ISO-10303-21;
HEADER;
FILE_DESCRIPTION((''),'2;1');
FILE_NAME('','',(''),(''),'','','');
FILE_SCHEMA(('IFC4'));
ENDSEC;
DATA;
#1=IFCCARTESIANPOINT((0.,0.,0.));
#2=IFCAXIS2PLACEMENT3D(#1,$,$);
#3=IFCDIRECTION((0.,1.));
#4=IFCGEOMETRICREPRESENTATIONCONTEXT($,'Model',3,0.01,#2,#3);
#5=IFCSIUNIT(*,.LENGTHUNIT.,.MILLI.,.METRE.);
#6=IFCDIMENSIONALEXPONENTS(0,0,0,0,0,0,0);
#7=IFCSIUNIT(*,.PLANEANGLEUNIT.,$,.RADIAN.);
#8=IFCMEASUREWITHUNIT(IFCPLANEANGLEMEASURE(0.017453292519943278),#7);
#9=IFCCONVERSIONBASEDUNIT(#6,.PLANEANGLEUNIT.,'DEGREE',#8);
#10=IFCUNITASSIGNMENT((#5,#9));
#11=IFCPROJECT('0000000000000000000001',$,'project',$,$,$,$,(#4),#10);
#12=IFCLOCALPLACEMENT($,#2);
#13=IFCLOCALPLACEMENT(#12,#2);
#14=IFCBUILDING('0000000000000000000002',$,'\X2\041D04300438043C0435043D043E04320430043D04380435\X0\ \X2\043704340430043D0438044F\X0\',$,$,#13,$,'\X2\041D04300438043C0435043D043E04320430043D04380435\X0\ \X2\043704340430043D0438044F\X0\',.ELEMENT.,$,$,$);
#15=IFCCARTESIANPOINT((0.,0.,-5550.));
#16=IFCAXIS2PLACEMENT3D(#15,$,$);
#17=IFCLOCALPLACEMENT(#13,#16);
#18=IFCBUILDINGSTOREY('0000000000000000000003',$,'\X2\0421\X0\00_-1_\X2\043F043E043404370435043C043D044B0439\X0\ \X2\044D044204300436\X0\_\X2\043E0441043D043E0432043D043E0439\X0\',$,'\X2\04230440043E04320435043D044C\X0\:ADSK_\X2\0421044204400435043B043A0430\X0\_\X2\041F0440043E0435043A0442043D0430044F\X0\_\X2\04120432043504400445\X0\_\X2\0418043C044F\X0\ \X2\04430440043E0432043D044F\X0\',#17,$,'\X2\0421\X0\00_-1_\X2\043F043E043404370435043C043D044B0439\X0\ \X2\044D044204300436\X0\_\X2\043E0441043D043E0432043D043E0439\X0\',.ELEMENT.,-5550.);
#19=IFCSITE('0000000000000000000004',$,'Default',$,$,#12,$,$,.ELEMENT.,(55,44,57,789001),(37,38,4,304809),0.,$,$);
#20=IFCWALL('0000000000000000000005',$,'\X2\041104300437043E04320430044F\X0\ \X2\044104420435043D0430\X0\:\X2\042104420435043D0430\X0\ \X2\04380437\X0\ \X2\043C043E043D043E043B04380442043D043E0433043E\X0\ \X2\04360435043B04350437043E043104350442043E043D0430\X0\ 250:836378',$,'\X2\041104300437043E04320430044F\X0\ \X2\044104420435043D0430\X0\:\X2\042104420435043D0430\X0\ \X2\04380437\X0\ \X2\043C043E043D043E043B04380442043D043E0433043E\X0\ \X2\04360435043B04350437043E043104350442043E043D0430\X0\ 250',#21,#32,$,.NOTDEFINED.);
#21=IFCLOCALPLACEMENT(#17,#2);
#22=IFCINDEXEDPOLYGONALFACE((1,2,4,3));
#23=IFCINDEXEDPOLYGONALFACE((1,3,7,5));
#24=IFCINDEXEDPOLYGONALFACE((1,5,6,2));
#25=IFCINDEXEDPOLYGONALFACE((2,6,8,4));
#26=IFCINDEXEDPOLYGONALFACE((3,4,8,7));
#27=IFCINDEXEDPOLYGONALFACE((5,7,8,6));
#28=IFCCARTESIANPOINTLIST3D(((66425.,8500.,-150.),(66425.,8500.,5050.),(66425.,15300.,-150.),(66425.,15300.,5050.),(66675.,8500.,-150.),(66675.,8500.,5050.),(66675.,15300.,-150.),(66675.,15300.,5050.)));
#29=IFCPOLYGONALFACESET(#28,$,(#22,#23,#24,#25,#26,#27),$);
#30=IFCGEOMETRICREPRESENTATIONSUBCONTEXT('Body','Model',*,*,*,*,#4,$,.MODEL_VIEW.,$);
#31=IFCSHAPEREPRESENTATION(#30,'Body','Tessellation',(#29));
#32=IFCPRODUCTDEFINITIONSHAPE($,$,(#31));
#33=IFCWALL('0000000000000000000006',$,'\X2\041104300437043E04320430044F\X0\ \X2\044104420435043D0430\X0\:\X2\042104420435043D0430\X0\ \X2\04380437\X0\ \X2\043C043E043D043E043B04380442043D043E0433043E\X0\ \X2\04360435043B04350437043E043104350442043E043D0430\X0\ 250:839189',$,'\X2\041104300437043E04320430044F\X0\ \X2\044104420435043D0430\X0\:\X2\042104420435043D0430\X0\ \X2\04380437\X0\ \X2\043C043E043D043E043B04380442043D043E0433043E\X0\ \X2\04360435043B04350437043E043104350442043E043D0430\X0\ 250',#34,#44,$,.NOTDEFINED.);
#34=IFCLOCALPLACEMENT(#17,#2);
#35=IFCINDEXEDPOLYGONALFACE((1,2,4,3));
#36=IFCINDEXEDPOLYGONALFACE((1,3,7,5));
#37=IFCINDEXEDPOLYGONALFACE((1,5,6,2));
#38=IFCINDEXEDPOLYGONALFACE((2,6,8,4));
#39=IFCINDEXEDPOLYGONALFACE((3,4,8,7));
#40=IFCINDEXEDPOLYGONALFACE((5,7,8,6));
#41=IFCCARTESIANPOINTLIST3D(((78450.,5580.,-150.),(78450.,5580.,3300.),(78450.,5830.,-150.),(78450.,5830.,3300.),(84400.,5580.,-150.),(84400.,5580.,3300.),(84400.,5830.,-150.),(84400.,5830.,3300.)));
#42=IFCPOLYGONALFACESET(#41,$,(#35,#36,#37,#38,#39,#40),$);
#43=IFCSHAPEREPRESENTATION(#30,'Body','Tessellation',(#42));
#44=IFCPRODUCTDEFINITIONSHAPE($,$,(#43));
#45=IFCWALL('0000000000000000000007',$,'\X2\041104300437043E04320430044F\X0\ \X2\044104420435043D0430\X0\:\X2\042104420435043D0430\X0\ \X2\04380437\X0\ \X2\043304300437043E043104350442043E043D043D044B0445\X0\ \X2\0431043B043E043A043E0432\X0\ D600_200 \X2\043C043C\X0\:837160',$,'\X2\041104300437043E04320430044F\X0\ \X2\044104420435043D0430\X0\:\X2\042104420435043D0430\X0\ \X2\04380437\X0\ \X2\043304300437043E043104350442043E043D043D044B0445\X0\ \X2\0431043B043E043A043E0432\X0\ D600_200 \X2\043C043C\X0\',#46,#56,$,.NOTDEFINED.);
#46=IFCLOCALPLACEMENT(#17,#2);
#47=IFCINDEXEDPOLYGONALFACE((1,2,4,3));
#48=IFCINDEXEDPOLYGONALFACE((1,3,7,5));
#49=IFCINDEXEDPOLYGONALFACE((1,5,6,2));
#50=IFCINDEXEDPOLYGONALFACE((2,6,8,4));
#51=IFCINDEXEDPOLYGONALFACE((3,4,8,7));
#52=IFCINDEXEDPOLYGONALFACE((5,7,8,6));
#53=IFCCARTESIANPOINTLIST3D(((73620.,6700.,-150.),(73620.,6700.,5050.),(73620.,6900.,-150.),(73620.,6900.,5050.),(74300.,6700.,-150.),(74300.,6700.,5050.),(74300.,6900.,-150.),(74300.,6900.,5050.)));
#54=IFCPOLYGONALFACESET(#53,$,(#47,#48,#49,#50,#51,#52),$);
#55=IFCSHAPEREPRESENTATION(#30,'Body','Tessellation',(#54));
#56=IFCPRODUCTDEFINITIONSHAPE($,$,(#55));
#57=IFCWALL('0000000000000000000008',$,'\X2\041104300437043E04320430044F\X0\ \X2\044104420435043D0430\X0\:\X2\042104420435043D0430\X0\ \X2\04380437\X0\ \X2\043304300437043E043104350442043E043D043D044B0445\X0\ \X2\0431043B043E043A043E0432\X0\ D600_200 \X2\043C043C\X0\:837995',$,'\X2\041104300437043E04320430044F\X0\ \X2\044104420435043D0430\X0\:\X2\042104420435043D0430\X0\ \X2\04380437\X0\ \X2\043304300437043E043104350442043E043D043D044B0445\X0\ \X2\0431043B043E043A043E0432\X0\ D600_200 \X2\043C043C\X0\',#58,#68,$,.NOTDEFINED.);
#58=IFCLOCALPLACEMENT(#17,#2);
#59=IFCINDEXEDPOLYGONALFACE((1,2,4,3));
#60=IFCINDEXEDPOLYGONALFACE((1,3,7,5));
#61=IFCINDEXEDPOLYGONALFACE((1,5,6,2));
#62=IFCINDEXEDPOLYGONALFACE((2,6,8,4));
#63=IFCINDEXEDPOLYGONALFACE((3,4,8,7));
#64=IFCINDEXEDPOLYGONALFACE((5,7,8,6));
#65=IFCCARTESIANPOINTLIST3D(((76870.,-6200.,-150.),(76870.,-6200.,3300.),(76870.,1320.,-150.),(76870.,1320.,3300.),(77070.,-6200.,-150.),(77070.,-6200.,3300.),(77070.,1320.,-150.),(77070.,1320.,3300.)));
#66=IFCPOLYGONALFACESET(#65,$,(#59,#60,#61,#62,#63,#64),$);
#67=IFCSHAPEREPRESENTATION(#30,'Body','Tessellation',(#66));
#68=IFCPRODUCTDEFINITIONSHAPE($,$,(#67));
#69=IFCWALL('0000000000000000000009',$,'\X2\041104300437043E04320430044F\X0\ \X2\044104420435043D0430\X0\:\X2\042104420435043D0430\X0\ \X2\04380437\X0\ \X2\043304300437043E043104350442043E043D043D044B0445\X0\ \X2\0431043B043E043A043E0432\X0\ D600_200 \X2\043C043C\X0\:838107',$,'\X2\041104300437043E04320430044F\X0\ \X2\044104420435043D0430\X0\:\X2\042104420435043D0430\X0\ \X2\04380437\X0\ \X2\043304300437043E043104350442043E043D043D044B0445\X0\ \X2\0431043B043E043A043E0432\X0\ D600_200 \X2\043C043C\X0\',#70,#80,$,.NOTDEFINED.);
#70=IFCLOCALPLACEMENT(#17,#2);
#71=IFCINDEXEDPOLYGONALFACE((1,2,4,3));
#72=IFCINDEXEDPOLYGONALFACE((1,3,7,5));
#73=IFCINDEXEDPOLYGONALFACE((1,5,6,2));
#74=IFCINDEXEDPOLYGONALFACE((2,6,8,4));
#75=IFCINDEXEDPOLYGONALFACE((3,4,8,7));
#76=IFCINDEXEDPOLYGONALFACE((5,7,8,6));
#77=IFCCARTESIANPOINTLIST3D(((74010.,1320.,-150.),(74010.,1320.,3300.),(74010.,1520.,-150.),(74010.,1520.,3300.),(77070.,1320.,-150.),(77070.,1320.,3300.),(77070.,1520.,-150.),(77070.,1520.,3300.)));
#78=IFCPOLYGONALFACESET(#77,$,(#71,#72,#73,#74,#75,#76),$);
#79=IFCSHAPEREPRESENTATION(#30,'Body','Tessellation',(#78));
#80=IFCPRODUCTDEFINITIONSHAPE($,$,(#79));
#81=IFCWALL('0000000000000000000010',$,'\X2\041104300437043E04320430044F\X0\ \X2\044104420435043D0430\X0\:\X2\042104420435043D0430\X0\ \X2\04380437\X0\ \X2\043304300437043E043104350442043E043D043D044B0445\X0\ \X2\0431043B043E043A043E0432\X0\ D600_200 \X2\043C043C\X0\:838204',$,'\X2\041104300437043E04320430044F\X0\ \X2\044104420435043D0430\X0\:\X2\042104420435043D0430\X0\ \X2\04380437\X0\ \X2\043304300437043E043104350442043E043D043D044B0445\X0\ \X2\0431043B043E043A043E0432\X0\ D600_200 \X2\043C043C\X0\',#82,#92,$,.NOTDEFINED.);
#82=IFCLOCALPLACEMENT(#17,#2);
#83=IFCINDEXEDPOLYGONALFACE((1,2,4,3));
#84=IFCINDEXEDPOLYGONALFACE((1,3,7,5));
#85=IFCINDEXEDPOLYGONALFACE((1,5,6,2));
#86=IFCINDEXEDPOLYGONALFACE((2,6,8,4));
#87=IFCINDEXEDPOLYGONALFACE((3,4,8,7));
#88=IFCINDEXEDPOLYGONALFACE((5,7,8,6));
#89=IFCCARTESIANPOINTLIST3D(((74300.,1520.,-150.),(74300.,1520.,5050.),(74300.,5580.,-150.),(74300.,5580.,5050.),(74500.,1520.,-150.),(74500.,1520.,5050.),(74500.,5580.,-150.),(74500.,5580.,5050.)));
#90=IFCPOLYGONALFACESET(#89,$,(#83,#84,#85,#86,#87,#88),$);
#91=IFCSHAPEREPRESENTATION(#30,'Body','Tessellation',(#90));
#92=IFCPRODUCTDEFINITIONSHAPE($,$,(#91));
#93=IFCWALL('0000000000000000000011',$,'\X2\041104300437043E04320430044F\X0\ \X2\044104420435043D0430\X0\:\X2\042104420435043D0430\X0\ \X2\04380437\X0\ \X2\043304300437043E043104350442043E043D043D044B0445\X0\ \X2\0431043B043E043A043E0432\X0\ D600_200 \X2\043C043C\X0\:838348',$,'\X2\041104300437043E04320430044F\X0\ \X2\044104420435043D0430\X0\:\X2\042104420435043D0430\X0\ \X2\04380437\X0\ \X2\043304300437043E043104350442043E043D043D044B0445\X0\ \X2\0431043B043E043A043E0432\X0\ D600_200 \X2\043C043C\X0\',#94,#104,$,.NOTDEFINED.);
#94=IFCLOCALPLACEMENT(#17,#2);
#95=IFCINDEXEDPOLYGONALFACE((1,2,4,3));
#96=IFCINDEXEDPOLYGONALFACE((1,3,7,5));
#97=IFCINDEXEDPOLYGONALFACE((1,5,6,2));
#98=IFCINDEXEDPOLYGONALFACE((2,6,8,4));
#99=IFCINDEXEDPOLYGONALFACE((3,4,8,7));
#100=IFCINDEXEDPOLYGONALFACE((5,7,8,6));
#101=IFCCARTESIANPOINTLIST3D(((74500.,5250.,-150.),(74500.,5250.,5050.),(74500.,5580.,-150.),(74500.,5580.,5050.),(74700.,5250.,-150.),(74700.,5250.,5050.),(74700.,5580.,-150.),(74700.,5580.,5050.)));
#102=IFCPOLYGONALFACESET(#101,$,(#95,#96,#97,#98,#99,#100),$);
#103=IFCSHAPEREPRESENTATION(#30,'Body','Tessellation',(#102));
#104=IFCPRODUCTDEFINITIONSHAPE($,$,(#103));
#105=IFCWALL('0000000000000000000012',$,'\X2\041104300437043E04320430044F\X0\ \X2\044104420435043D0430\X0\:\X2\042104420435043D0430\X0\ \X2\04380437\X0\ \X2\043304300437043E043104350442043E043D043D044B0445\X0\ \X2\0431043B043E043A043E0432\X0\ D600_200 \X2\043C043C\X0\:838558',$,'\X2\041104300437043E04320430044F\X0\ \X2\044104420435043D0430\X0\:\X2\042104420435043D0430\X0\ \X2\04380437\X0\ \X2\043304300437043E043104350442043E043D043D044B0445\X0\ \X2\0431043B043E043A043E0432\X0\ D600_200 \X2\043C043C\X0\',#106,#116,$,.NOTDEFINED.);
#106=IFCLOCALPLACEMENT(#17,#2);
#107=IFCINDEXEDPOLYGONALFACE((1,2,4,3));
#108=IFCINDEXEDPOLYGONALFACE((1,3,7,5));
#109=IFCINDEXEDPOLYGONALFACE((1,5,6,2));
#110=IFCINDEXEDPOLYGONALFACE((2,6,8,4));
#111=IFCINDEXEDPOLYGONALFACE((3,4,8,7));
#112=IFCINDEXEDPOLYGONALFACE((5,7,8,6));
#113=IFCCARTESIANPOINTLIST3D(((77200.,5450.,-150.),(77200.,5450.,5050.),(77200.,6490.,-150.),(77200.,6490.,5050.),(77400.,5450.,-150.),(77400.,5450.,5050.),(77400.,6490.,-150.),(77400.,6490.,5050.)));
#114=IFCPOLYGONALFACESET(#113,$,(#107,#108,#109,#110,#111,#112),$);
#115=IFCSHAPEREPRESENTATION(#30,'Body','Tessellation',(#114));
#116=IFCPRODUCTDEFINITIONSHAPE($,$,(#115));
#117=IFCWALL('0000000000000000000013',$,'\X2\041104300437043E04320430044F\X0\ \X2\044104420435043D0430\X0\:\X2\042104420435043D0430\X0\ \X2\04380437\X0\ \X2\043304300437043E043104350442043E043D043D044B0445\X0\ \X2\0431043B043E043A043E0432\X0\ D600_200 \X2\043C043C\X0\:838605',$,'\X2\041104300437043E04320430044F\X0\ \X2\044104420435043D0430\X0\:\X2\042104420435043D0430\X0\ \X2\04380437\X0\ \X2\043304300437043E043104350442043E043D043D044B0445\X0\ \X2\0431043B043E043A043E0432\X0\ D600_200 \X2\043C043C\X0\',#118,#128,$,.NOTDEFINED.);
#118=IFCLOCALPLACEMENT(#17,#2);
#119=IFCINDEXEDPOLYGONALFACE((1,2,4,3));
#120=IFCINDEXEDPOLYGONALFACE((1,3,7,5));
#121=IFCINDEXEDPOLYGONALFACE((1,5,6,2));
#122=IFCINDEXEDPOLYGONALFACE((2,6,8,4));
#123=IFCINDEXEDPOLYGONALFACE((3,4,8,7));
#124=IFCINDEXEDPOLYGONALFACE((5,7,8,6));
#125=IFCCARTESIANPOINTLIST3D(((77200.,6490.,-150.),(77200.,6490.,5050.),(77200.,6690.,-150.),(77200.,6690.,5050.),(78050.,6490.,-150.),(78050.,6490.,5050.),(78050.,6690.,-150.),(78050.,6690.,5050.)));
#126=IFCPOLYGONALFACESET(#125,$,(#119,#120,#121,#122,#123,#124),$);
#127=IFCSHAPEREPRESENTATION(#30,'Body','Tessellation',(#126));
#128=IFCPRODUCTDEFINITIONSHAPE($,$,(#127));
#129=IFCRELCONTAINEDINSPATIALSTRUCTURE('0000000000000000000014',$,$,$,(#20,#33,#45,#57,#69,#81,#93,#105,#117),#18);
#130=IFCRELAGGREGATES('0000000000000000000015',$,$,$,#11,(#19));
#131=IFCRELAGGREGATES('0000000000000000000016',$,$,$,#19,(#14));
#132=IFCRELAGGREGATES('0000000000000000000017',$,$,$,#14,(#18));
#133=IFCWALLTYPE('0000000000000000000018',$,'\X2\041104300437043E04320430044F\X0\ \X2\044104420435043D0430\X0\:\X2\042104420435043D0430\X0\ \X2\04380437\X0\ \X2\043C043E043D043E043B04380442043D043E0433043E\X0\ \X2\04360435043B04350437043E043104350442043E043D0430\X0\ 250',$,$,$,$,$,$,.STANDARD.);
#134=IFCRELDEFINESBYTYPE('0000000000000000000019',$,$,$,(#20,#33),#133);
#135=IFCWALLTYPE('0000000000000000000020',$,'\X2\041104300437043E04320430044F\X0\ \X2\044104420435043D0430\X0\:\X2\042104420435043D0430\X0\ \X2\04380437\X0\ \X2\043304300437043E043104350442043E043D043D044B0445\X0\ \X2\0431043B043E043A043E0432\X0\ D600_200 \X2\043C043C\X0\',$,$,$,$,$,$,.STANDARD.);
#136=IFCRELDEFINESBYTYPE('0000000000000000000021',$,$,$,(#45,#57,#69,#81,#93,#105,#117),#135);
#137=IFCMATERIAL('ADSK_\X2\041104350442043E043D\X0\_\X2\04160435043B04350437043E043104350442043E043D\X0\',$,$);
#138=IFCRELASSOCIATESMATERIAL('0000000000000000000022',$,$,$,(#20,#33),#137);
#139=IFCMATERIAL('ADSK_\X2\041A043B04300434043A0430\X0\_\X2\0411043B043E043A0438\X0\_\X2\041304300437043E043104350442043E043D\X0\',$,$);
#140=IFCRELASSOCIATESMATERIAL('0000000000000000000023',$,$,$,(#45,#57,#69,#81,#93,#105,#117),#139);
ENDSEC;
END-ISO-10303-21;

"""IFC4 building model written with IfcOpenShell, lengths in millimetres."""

from ifc_helpers import new_model, entity, si_unit, converted_unit, direction, frame, origin, place, context, subcontext, project, spatial, indexed_curve, outline, extrude, material, type_object, element, save


model = new_model("IFC4")

# Units and contexts
model_context = context("Model", 3, precision=0.01, world=origin(), true_north=direction((0.0, 1.0)))
body_context = subcontext(model_context, "Body", "Model", "MODEL_VIEW")
ifc_project = project(units=[si_unit("LENGTHUNIT", "METRE", prefix="MILLI"), converted_unit("PLANEANGLEUNIT", "DEGREE", entity("IfcPlaneAngleMeasure", 0.017453292519943278), si_unit("PLANEANGLEUNIT", "RADIAN"), dimensions=[0, 0, 0, 0, 0, 0, 0])], contexts=[model_context])

# Site, building, storey
site_placement = place(None, origin())
site = spatial("IfcSite", under=ifc_project, at=site_placement, Name="Default", CompositionType="ELEMENT", RefLatitude=(55, 44, 57, 789001), RefLongitude=(37, 38, 4, 304809), RefElevation=0.0)
building_placement = place(site_placement, origin())
building = spatial("IfcBuilding", under=site, at=building_placement, Name="Наименование здания", LongName="Наименование здания", CompositionType="ELEMENT")
storey_placement = place(building_placement, frame((0.0, 0.0, -5550.0)))
storey = spatial("IfcBuildingStorey", under=building, at=storey_placement, Name="С00_-1_подземный этаж_основной", ObjectType="Уровень:ADSK_Стрелка_Проектная_Вверх_Имя уровня", LongName="С00_-1_подземный этаж_основной", CompositionType="ELEMENT", Elevation=-5550.0)

# Shared definitions
ifc_material_1 = material(Name="ADSK_Бетон_Железобетон")

# Walls
wall_type_1 = type_object("IfcWallType", Name="Базовая стена:Стена из монолитного железобетона 250", PredefinedType="STANDARD")
wall_1_placement = place(storey_placement, frame((66550.0, 8500.0, -150.0), z_axis=(0.0, 0.0, 1.0), x_axis=(0.0, 1.0, 0.0)))
element("IfcWall", 1, at=wall_1_placement, inside=storey, type_object=wall_type_1, material=ifc_material_1, Name="Базовая стена:Стена из монолитного железобетона 250:836378", ObjectType="Базовая стена:Стена из монолитного железобетона 250", PredefinedType="NOTDEFINED", context=body_context, shape_type="SweptSolid", body=[
    extrude(outline(indexed_curve([(6800.0, 125.0), (0.0, 125.0), (0.0, -125.0), (6800.0, -125.0), (6800.0, 125.0)], self_intersect=False)), origin(), (0.0, 0.0, 1.0), 5200.0),
])
wall_2_placement = place(storey_placement, frame((78450.0, 5705.0, -150.0)))
element("IfcWall", 2, at=wall_2_placement, inside=storey, type_object=wall_type_1, material=ifc_material_1, Name="Базовая стена:Стена из монолитного железобетона 250:839189", ObjectType="Базовая стена:Стена из монолитного железобетона 250", PredefinedType="NOTDEFINED", context=body_context, shape_type="SweptSolid", body=[
    extrude(outline(indexed_curve([(5950.0, 125.0), (0.0, 125.0), (0.0, -125.0), (5950.0, -125.0), (5950.0, 125.0)], self_intersect=False)), origin(), (0.0, 0.0, 1.0), 3450.0),
])
ifc_material_2 = material(Name="ADSK_Кладка_Блоки_Газобетон")
wall_type_2 = type_object("IfcWallType", Name="Базовая стена:Стена из газобетонных блоков D600_200 мм", PredefinedType="STANDARD")
wall_3_placement = place(storey_placement, frame((73620.0, 6800.0, -150.0)))
element("IfcWall", 3, at=wall_3_placement, inside=storey, type_object=wall_type_2, material=ifc_material_2, Name="Базовая стена:Стена из газобетонных блоков D600_200 мм:837160", ObjectType="Базовая стена:Стена из газобетонных блоков D600_200 мм", PredefinedType="NOTDEFINED", context=body_context, shape_type="SweptSolid", body=[
    extrude(outline(indexed_curve([(680.0, 100.0), (0.0, 100.0), (0.0, -100.0), (680.0, -100.0), (680.0, 100.0)], self_intersect=False)), origin(), (0.0, 0.0, 1.0), 5200.0),
])
wall_4_placement = place(storey_placement, frame((76970.0, -6200.0, -150.0), z_axis=(0.0, 0.0, 1.0), x_axis=(0.0, 1.0, 0.0)))
element("IfcWall", 4, at=wall_4_placement, inside=storey, type_object=wall_type_2, material=ifc_material_2, Name="Базовая стена:Стена из газобетонных блоков D600_200 мм:837995", ObjectType="Базовая стена:Стена из газобетонных блоков D600_200 мм", PredefinedType="NOTDEFINED", context=body_context, shape_type="SweptSolid", body=[
    extrude(outline(indexed_curve([(7520.0, 100.0), (0.0, 100.0), (0.0, -100.0), (7520.0, -100.0), (7520.0, 100.0)], self_intersect=False)), origin(), (0.0, 0.0, 1.0), 3450.0),
])
wall_5_placement = place(storey_placement, frame((77070.0, 1420.0, -150.0), z_axis=(0.0, 0.0, 1.0), x_axis=(-1.0, 0.0, 0.0)))
element("IfcWall", 5, at=wall_5_placement, inside=storey, type_object=wall_type_2, material=ifc_material_2, Name="Базовая стена:Стена из газобетонных блоков D600_200 мм:838107", ObjectType="Базовая стена:Стена из газобетонных блоков D600_200 мм", PredefinedType="NOTDEFINED", context=body_context, shape_type="SweptSolid", body=[
    extrude(outline(indexed_curve([(3060.0, 100.0), (0.0, 100.0), (0.0, -100.0), (3060.0, -100.0), (3060.0, 100.0)], self_intersect=False)), origin(), (0.0, 0.0, 1.0), 3450.0),
])
wall_6_placement = place(storey_placement, frame((74400.0, 1520.0, -150.0), z_axis=(0.0, 0.0, 1.0), x_axis=(0.0, 1.0, 0.0)))
element("IfcWall", 6, at=wall_6_placement, inside=storey, type_object=wall_type_2, material=ifc_material_2, Name="Базовая стена:Стена из газобетонных блоков D600_200 мм:838204", ObjectType="Базовая стена:Стена из газобетонных блоков D600_200 мм", PredefinedType="NOTDEFINED", context=body_context, shape_type="SweptSolid", body=[
    extrude(outline(indexed_curve([(4060.0, 100.0), (0.0, 100.0), (0.0, -100.0), (4060.0, -100.0), (4060.0, 100.0)], self_intersect=False)), origin(), (0.0, 0.0, 1.0), 5200.0),
])
wall_7_placement = place(storey_placement, frame((74600.0, 5580.0, -150.0), z_axis=(0.0, 0.0, 1.0), x_axis=(0.0, -1.0, 0.0)))
element("IfcWall", 7, at=wall_7_placement, inside=storey, type_object=wall_type_2, material=ifc_material_2, Name="Базовая стена:Стена из газобетонных блоков D600_200 мм:838348", ObjectType="Базовая стена:Стена из газобетонных блоков D600_200 мм", PredefinedType="NOTDEFINED", context=body_context, shape_type="SweptSolid", body=[
    extrude(outline(indexed_curve([(330.0, 100.0), (0.0, 100.0), (0.0, -100.0), (330.0, -100.0), (330.0, 100.0)], self_intersect=False)), origin(), (0.0, 0.0, 1.0), 5200.0),
])
wall_8_placement = place(storey_placement, frame((77300.0, 5450.0, -150.0), z_axis=(0.0, 0.0, 1.0), x_axis=(0.0, 1.0, 0.0)))
element("IfcWall", 8, at=wall_8_placement, inside=storey, type_object=wall_type_2, material=ifc_material_2, Name="Базовая стена:Стена из газобетонных блоков D600_200 мм:838558", ObjectType="Базовая стена:Стена из газобетонных блоков D600_200 мм", PredefinedType="NOTDEFINED", context=body_context, shape_type="SweptSolid", body=[
    extrude(outline(indexed_curve([(1040.0, 100.0), (0.0, 100.0), (0.0, -100.0), (1040.0, -100.0), (1040.0, 100.0)], self_intersect=False)), origin(), (0.0, 0.0, 1.0), 5200.0),
])
wall_9_placement = place(storey_placement, frame((77200.0, 6590.0, -150.0)))
element("IfcWall", 9, at=wall_9_placement, inside=storey, type_object=wall_type_2, material=ifc_material_2, Name="Базовая стена:Стена из газобетонных блоков D600_200 мм:838605", ObjectType="Базовая стена:Стена из газобетонных блоков D600_200 мм", PredefinedType="NOTDEFINED", context=body_context, shape_type="SweptSolid", body=[
    extrude(outline(indexed_curve([(850.0, 100.0), (0.0, 100.0), (0.0, -100.0), (850.0, -100.0), (850.0, 100.0)], self_intersect=False)), origin(), (0.0, 0.0, 1.0), 5200.0),
])

save(model, "model.ifc")
